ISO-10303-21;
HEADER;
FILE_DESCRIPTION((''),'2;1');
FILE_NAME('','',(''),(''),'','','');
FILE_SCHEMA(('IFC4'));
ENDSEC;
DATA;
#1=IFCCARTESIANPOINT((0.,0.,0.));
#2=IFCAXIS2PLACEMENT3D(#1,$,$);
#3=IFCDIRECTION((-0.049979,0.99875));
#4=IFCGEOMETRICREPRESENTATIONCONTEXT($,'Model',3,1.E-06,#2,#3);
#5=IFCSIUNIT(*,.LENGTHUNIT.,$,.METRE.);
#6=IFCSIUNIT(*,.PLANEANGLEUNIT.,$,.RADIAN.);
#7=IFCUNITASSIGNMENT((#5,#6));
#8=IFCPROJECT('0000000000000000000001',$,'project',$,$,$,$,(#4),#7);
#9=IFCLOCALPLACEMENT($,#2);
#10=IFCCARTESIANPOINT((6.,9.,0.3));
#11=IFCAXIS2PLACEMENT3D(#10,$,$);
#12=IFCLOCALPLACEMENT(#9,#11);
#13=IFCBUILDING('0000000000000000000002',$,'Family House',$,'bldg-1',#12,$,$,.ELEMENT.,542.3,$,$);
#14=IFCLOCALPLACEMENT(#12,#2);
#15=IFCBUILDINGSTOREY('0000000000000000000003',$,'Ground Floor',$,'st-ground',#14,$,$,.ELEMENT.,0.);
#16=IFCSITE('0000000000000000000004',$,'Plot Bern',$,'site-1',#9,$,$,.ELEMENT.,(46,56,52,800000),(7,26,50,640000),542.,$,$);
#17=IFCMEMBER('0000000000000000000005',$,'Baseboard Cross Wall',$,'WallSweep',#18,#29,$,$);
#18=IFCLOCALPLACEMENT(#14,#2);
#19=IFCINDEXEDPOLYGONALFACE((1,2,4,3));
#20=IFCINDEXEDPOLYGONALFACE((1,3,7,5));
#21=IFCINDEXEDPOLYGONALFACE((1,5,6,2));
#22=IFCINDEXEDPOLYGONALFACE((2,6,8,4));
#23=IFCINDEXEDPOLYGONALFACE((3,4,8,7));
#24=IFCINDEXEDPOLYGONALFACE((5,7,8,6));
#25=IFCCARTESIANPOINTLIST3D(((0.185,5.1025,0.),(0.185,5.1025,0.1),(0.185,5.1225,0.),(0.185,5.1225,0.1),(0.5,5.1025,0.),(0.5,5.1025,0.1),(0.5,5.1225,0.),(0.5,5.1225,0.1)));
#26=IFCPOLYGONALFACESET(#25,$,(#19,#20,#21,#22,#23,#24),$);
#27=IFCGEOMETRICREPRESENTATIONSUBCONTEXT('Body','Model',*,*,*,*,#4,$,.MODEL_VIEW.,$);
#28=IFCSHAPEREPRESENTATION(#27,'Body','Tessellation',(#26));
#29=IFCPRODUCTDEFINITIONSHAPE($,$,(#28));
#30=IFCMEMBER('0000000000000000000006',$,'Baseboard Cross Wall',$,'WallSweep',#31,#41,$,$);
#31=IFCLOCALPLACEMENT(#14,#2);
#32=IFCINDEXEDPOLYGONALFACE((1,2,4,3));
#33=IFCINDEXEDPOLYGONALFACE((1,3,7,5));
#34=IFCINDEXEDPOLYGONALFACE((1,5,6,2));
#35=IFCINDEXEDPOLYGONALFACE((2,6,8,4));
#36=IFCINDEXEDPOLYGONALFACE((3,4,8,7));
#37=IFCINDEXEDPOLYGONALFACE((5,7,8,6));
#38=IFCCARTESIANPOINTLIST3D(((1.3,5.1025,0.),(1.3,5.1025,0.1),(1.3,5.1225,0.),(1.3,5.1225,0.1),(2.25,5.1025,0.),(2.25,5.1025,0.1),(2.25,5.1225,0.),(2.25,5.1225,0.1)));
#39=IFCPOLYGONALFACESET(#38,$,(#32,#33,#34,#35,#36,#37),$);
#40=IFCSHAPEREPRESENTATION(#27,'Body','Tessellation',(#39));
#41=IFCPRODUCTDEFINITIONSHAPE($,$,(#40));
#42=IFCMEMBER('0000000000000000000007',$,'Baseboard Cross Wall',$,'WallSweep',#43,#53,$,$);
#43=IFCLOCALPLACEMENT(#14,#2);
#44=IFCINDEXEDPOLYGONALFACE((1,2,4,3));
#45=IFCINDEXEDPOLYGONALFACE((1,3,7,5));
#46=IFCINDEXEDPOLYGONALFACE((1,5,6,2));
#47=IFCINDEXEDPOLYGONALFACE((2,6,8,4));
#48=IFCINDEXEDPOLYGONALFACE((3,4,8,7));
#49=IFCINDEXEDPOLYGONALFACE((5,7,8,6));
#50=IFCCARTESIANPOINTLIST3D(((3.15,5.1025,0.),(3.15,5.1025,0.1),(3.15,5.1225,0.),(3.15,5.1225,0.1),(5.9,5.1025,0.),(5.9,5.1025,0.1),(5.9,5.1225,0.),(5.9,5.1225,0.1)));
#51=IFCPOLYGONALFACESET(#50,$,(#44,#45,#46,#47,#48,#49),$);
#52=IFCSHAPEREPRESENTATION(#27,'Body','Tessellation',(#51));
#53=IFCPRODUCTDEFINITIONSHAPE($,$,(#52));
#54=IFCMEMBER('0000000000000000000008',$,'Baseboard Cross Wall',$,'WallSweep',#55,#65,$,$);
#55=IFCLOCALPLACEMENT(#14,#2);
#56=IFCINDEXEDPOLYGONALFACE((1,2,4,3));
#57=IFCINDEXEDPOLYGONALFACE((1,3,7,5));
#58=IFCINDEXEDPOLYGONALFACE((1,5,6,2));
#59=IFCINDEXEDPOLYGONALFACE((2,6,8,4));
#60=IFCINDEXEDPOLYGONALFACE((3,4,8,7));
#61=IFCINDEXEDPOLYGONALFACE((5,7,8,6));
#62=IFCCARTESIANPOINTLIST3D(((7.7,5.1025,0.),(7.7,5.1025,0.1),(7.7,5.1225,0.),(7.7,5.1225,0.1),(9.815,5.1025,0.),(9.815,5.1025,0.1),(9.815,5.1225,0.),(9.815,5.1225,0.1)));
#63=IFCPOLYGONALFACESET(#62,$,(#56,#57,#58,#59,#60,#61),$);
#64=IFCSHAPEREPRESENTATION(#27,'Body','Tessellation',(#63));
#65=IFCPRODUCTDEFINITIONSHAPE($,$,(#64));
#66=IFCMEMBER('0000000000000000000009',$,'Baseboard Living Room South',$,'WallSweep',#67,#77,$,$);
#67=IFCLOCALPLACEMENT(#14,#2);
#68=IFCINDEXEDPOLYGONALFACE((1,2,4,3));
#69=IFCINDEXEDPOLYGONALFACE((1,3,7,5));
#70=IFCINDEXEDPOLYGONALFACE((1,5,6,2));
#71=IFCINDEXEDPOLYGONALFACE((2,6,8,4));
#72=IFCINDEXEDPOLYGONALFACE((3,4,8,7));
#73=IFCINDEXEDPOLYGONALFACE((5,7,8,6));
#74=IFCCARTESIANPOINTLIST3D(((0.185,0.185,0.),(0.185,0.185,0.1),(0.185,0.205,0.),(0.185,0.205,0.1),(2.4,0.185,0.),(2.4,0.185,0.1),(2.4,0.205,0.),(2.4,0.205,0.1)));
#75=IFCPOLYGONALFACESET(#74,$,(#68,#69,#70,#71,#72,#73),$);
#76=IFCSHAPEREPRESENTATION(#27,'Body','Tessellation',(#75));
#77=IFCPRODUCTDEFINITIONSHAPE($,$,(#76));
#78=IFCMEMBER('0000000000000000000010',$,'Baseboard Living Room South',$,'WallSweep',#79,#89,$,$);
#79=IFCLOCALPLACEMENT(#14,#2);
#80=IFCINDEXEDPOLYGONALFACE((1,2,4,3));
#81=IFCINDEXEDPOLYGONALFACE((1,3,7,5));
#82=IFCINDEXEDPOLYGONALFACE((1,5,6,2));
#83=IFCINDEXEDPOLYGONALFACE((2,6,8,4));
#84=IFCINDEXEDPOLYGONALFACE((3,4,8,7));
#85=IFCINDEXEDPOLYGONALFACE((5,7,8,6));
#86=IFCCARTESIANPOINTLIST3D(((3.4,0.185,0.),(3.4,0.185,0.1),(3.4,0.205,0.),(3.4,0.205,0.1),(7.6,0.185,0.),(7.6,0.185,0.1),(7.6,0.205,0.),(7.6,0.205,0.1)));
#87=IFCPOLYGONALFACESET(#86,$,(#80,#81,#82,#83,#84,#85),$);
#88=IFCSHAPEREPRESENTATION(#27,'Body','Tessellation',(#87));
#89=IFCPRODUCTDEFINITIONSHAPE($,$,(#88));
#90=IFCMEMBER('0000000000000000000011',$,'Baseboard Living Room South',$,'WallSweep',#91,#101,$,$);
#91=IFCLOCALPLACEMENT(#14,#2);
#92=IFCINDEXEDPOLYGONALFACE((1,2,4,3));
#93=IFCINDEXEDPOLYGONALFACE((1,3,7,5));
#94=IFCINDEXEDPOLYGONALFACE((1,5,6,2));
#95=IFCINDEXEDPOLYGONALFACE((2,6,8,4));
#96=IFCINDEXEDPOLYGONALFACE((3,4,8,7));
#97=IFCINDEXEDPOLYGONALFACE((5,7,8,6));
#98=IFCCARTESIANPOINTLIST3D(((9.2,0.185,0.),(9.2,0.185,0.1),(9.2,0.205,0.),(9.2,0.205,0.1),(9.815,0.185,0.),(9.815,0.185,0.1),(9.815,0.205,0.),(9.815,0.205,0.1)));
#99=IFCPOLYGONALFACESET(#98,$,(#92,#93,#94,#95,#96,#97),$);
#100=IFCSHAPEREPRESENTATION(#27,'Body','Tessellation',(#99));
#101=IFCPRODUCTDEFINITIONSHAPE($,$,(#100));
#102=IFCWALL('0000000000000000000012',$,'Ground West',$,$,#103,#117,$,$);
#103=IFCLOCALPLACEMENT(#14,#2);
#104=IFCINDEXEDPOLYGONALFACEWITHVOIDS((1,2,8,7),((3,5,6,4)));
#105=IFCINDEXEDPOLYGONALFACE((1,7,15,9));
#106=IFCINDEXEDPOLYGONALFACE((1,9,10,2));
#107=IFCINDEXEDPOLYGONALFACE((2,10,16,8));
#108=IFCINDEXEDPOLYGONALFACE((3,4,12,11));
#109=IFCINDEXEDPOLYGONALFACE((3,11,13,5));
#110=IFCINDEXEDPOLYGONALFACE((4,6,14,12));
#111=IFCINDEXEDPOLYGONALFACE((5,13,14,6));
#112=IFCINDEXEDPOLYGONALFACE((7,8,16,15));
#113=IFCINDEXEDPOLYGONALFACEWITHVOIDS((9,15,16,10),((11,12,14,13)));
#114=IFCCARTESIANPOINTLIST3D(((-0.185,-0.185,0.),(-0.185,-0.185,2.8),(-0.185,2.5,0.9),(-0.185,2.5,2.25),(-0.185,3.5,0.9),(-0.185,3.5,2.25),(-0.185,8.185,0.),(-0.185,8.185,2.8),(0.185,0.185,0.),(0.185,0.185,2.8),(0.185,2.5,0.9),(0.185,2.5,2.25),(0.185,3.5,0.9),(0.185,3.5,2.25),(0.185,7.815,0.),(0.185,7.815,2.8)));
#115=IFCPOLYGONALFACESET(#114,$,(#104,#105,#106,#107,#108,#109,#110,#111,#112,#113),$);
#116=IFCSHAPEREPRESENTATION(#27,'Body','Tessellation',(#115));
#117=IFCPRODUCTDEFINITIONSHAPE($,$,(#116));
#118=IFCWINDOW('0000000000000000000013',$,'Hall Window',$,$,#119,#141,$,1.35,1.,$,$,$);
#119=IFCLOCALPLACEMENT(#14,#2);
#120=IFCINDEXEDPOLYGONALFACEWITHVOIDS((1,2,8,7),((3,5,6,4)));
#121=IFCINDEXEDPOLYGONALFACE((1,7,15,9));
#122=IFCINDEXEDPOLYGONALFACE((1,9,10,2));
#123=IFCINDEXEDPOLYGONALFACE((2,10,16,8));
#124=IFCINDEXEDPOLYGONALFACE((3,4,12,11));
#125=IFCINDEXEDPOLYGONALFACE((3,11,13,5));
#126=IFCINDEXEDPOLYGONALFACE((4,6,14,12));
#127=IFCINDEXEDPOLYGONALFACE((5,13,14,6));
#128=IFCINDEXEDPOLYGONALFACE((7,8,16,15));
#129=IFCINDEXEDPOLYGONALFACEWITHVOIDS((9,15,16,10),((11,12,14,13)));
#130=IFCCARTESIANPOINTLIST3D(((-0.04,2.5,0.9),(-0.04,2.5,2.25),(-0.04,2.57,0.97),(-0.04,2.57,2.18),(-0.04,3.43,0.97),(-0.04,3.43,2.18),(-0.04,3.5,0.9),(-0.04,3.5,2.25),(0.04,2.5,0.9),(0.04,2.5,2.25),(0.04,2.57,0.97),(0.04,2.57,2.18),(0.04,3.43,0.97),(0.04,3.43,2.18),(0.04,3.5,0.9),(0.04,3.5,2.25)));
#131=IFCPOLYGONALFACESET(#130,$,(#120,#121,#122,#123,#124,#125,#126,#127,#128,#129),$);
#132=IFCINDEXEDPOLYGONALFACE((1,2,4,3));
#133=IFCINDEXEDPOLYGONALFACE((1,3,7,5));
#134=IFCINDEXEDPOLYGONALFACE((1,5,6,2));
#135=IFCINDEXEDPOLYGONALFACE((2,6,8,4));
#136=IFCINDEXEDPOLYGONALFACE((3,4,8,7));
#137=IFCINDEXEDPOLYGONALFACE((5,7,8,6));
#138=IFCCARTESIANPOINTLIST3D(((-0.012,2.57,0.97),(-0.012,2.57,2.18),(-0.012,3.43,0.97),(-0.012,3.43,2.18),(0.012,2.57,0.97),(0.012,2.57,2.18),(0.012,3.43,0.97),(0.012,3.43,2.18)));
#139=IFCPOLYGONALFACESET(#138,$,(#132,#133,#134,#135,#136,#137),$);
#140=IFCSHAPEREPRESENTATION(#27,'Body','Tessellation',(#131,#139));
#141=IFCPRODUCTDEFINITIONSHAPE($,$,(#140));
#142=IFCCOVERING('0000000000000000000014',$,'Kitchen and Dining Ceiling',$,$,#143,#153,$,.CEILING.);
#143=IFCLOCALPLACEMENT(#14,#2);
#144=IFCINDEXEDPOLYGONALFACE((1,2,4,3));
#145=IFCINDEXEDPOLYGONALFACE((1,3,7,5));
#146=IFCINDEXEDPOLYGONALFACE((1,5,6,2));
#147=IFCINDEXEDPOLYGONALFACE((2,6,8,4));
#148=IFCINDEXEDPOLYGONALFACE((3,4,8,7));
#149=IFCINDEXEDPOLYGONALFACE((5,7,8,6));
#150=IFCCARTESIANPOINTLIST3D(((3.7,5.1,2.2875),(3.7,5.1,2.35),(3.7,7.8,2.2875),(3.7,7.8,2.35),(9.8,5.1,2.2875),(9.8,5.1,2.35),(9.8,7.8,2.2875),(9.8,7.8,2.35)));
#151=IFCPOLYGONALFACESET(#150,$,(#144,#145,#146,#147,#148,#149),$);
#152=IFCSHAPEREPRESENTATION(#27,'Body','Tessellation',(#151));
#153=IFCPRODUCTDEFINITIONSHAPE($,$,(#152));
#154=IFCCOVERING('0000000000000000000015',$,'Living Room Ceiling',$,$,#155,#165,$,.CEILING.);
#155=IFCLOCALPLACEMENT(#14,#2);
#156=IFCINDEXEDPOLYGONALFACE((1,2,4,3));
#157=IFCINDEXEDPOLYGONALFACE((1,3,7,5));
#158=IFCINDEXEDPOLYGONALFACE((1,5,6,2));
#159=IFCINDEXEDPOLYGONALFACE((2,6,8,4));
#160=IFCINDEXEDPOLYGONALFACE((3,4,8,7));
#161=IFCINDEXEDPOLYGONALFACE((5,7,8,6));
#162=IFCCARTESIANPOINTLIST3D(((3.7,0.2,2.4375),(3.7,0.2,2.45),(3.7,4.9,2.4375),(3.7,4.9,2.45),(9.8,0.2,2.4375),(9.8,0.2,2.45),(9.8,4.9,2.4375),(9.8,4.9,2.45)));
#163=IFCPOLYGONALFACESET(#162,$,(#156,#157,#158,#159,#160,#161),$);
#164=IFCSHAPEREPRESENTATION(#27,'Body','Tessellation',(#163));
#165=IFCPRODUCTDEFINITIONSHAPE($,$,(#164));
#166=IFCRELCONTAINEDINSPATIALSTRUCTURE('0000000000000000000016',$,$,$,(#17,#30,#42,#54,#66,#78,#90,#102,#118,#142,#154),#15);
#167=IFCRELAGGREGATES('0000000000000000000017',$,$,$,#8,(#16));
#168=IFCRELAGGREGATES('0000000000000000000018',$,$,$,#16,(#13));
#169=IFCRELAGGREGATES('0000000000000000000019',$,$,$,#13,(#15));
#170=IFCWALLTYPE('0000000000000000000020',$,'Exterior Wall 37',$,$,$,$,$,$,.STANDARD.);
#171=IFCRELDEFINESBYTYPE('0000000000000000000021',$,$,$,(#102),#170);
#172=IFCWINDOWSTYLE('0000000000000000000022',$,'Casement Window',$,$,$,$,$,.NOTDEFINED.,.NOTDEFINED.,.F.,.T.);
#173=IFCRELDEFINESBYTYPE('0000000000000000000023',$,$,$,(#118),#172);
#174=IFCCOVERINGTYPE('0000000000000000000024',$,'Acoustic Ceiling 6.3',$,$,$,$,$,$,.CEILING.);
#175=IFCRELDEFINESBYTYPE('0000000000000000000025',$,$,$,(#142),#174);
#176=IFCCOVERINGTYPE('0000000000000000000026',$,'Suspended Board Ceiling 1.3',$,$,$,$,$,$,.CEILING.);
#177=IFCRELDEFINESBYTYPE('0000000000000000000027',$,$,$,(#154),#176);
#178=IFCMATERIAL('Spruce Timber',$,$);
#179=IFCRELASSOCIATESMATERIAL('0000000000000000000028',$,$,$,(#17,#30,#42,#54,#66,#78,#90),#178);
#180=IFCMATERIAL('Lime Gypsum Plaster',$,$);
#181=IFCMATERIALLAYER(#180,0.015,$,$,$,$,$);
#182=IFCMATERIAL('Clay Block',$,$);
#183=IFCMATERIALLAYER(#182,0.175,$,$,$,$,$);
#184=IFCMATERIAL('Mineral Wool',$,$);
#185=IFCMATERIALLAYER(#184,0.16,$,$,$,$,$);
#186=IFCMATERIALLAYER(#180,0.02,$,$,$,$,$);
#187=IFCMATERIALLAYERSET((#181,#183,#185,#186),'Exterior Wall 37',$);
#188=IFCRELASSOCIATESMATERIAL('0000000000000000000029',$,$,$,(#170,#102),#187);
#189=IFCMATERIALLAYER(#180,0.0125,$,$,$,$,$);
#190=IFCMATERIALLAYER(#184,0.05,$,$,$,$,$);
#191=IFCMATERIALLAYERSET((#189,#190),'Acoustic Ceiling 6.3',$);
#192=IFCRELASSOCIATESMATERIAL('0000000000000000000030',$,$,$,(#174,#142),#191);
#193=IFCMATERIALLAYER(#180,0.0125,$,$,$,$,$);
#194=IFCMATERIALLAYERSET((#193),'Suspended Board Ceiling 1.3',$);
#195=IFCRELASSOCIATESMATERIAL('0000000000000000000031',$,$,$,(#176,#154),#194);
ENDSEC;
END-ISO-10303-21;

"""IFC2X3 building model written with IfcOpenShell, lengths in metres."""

from ifc_helpers import new_model, si_unit, direction, frame, frame_2d, origin, origin_2d, place, context, subcontext, project, spatial, polyline, rectangle, outline, extrude, material, layer, layer_set, layer_usage, type_object, element, fill, save


model = new_model("IFC2X3")

# Units and contexts
model_context = context("Model", 3, precision=1e-06, world=origin(), true_north=direction((-0.049979, 0.99875)))
body_context = subcontext(model_context, "Body", "Model", "MODEL_VIEW")
ifc_project = project(units=[si_unit("LENGTHUNIT", "METRE"), si_unit("PLANEANGLEUNIT", "RADIAN")], contexts=[model_context])

# Site, building, storey
site_placement = place(None, origin())
site = spatial("IfcSite", under=ifc_project, at=site_placement, Name="Plot Bern", ObjectType="site-1", CompositionType="ELEMENT", RefLatitude=(46, 56, 52, 800000), RefLongitude=(7, 26, 50, 640000), RefElevation=542.0)
building_placement = place(site_placement, frame((6.0, 9.0, 0.3)))
building = spatial("IfcBuilding", under=site, at=building_placement, Name="Family House", ObjectType="bldg-1", CompositionType="ELEMENT", ElevationOfRefHeight=542.3)
storey_placement = place(building_placement, origin())
storey = spatial("IfcBuildingStorey", under=building, at=storey_placement, Name="Ground Floor", ObjectType="st-ground", CompositionType="ELEMENT", Elevation=0.0)

# Members
ifc_material_1 = material(Name="Spruce Timber")
member_1_placement = place(storey_placement, origin())
element("IfcMember", 1, at=member_1_placement, inside=storey, material=ifc_material_1, Name="Baseboard Cross Wall", ObjectType="WallSweep", context=body_context, shape_type="SweptSolid", body=[
    extrude(outline(polyline([(0.0, 0.0), (0.02, 0.0), (0.02, 0.1), (0.0, 0.1), (0.0, 0.0)])), frame((0.185, 5.1025, 0.0), z_axis=(1.0, 0.0, 0.0), x_axis=(0.0, 1.0, 0.0)), (0.0, 0.0, 1.0), 0.315),
])
member_2_placement = place(storey_placement, origin())
element("IfcMember", 2, at=member_2_placement, inside=storey, material=ifc_material_1, Name="Baseboard Cross Wall", ObjectType="WallSweep", context=body_context, shape_type="SweptSolid", body=[
    extrude(outline(polyline([(0.0, 0.0), (0.02, 0.0), (0.02, 0.1), (0.0, 0.1), (0.0, 0.0)])), frame((1.3, 5.1025, 0.0), z_axis=(1.0, 0.0, 0.0), x_axis=(0.0, 1.0, 0.0)), (0.0, 0.0, 1.0), 0.95),
])
member_3_placement = place(storey_placement, origin())
element("IfcMember", 3, at=member_3_placement, inside=storey, material=ifc_material_1, Name="Baseboard Cross Wall", ObjectType="WallSweep", context=body_context, shape_type="SweptSolid", body=[
    extrude(outline(polyline([(0.0, 0.0), (0.02, 0.0), (0.02, 0.1), (0.0, 0.1), (0.0, 0.0)])), frame((3.15, 5.1025, 0.0), z_axis=(1.0, 0.0, 0.0), x_axis=(0.0, 1.0, 0.0)), (0.0, 0.0, 1.0), 2.75),
])
member_4_placement = place(storey_placement, origin())
element("IfcMember", 4, at=member_4_placement, inside=storey, material=ifc_material_1, Name="Baseboard Cross Wall", ObjectType="WallSweep", context=body_context, shape_type="SweptSolid", body=[
    extrude(outline(polyline([(0.0, 0.0), (0.02, 0.0), (0.02, 0.1), (0.0, 0.1), (0.0, 0.0)])), frame((7.7, 5.1025, 0.0), z_axis=(1.0, 0.0, 0.0), x_axis=(0.0, 1.0, 0.0)), (0.0, 0.0, 1.0), 2.115),
])
member_5_placement = place(storey_placement, origin())
element("IfcMember", 5, at=member_5_placement, inside=storey, material=ifc_material_1, Name="Baseboard Living Room South", ObjectType="WallSweep", context=body_context, shape_type="SweptSolid", body=[
    extrude(outline(polyline([(0.0, 0.0), (0.02, 0.0), (0.02, 0.1), (0.0, 0.1), (0.0, 0.0)])), frame((0.185, 0.185, 0.0), z_axis=(1.0, 0.0, 0.0), x_axis=(0.0, 1.0, 0.0)), (0.0, 0.0, 1.0), 2.215),
])
member_6_placement = place(storey_placement, origin())
element("IfcMember", 6, at=member_6_placement, inside=storey, material=ifc_material_1, Name="Baseboard Living Room South", ObjectType="WallSweep", context=body_context, shape_type="SweptSolid", body=[
    extrude(outline(polyline([(0.0, 0.0), (0.02, 0.0), (0.02, 0.1), (0.0, 0.1), (0.0, 0.0)])), frame((3.4, 0.185, 0.0), z_axis=(1.0, 0.0, 0.0), x_axis=(0.0, 1.0, 0.0)), (0.0, 0.0, 1.0), 4.2),
])
member_7_placement = place(storey_placement, origin())
element("IfcMember", 7, at=member_7_placement, inside=storey, material=ifc_material_1, Name="Baseboard Living Room South", ObjectType="WallSweep", context=body_context, shape_type="SweptSolid", body=[
    extrude(outline(polyline([(0.0, 0.0), (0.02, 0.0), (0.02, 0.1), (0.0, 0.1), (0.0, 0.0)])), frame((9.2, 0.185, 0.0), z_axis=(1.0, 0.0, 0.0), x_axis=(0.0, 1.0, 0.0)), (0.0, 0.0, 1.0), 0.615),
])

# Wall, opening, window
ifc_material_2 = material(Name="Lime Gypsum Plaster")
ifc_layer_1 = layer(ifc_material_2, 0.015)
ifc_material_3 = material(Name="Clay Block")
ifc_layer_2 = layer(ifc_material_3, 0.175)
ifc_material_4 = material(Name="Mineral Wool")
ifc_layer_3 = layer(ifc_material_4, 0.16)
ifc_layer_4 = layer(ifc_material_2, 0.02)
ifc_layer_set_1 = layer_set([ifc_layer_1, ifc_layer_2, ifc_layer_3, ifc_layer_4], Name="Exterior Wall 37")
ifc_layer_usage_1 = layer_usage(ifc_layer_set_1, "AXIS2", "NEGATIVE", 0.185)
wall_type = type_object("IfcWallType", Name="Exterior Wall 37", PredefinedType="STANDARD", material=ifc_layer_set_1)
wall_placement = place(storey_placement, origin())
wall = element("IfcWall", 8, at=wall_placement, inside=storey, type_object=wall_type, material=ifc_layer_usage_1, Name="Ground West", context=body_context, shape_type="SweptSolid", body=[
    extrude(outline(polyline([(-0.185, 8.185), (-0.185, -0.185), (0.185, 0.185), (0.185, 7.815), (-0.185, 8.185)])), origin(), (0.0, 0.0, 1.0), 2.8),
])
opening_placement = place(wall_placement, frame((0.0, 3.0, 0.9), z_axis=(0.0, 0.0, 1.0), x_axis=(0.0, -1.0, 0.0)))
opening = element("IfcOpeningElement", 9, at=opening_placement, cuts=wall, context=body_context, shape_type="SweptSolid", body=[
    extrude(rectangle(XDim=1.0, YDim=0.37, at=origin_2d()), origin(), (0.0, 0.0, 1.0), 1.35),
])
window_style = type_object("IfcWindowStyle", Name="Casement Window", ConstructionType="NOTDEFINED", OperationType="NOTDEFINED", ParameterTakesPrecedence=False, Sizeable=True)
window_placement = place(opening_placement, frame((0.0, 0.0, 0.0), z_axis=(0.0, -1.0, 0.0), x_axis=(1.0, 0.0, 0.0)))
window = element("IfcWindow", 10, at=window_placement, inside=storey, type_object=window_style, Name="Hall Window", OverallHeight=1.35, OverallWidth=1.0, context=body_context, shape_type="SweptSolid", body=[
    extrude(outline(polyline([(-0.5, 0.0), (0.5, 0.0), (0.5, 1.35), (-0.5, 1.35), (-0.5, 0.0)]), holes=[polyline([(-0.43, 0.07), (0.43, 0.07), (0.43, 1.28), (-0.43, 1.28), (-0.43, 0.07)])]), frame((0.0, 0.0, -0.04)), (0.0, 0.0, 1.0), 0.08),
    extrude(rectangle(XDim=0.86, YDim=1.21, at=frame_2d((0.0, 0.675))), frame((0.0, 0.0, -0.012)), (0.0, 0.0, 1.0), 0.024),
])
fill(opening, window)

# Coverings
ifc_layer_5 = layer(ifc_material_2, 0.0125)
ifc_layer_6 = layer(ifc_material_4, 0.05)
ifc_layer_set_2 = layer_set([ifc_layer_5, ifc_layer_6], Name="Acoustic Ceiling 6.3")
ifc_layer_usage_2 = layer_usage(ifc_layer_set_2, "AXIS3", "NEGATIVE", 0.0625)
covering_type_1 = type_object("IfcCoveringType", Name="Acoustic Ceiling 6.3", PredefinedType="CEILING", material=ifc_layer_set_2)
covering_1_placement = place(storey_placement, frame((0.0, 0.0, 2.2875)))
element("IfcCovering", 11, at=covering_1_placement, inside=storey, type_object=covering_type_1, material=ifc_layer_usage_2, Name="Kitchen and Dining Ceiling", PredefinedType="CEILING", context=body_context, shape_type="SweptSolid", body=[
    extrude(outline(polyline([(3.7, 5.1), (9.8, 5.1), (9.8, 7.8), (3.7, 7.8), (3.7, 5.1)])), origin(), (0.0, 0.0, 1.0), 0.0625),
])
ifc_layer_7 = layer(ifc_material_2, 0.0125)
ifc_layer_set_3 = layer_set([ifc_layer_7], Name="Suspended Board Ceiling 1.3")
ifc_layer_usage_3 = layer_usage(ifc_layer_set_3, "AXIS3", "NEGATIVE", 0.0125)
covering_type_2 = type_object("IfcCoveringType", Name="Suspended Board Ceiling 1.3", PredefinedType="CEILING", material=ifc_layer_set_3)
covering_2_placement = place(storey_placement, frame((0.0, 0.0, 2.4375)))
element("IfcCovering", 12, at=covering_2_placement, inside=storey, type_object=covering_type_2, material=ifc_layer_usage_3, Name="Living Room Ceiling", PredefinedType="CEILING", context=body_context, shape_type="SweptSolid", body=[
    extrude(outline(polyline([(3.7, 0.2), (9.8, 0.2), (9.8, 4.9), (3.7, 4.9), (3.7, 0.2)])), origin(), (0.0, 0.0, 1.0), 0.0125),
])

save(model, "model.ifc")
